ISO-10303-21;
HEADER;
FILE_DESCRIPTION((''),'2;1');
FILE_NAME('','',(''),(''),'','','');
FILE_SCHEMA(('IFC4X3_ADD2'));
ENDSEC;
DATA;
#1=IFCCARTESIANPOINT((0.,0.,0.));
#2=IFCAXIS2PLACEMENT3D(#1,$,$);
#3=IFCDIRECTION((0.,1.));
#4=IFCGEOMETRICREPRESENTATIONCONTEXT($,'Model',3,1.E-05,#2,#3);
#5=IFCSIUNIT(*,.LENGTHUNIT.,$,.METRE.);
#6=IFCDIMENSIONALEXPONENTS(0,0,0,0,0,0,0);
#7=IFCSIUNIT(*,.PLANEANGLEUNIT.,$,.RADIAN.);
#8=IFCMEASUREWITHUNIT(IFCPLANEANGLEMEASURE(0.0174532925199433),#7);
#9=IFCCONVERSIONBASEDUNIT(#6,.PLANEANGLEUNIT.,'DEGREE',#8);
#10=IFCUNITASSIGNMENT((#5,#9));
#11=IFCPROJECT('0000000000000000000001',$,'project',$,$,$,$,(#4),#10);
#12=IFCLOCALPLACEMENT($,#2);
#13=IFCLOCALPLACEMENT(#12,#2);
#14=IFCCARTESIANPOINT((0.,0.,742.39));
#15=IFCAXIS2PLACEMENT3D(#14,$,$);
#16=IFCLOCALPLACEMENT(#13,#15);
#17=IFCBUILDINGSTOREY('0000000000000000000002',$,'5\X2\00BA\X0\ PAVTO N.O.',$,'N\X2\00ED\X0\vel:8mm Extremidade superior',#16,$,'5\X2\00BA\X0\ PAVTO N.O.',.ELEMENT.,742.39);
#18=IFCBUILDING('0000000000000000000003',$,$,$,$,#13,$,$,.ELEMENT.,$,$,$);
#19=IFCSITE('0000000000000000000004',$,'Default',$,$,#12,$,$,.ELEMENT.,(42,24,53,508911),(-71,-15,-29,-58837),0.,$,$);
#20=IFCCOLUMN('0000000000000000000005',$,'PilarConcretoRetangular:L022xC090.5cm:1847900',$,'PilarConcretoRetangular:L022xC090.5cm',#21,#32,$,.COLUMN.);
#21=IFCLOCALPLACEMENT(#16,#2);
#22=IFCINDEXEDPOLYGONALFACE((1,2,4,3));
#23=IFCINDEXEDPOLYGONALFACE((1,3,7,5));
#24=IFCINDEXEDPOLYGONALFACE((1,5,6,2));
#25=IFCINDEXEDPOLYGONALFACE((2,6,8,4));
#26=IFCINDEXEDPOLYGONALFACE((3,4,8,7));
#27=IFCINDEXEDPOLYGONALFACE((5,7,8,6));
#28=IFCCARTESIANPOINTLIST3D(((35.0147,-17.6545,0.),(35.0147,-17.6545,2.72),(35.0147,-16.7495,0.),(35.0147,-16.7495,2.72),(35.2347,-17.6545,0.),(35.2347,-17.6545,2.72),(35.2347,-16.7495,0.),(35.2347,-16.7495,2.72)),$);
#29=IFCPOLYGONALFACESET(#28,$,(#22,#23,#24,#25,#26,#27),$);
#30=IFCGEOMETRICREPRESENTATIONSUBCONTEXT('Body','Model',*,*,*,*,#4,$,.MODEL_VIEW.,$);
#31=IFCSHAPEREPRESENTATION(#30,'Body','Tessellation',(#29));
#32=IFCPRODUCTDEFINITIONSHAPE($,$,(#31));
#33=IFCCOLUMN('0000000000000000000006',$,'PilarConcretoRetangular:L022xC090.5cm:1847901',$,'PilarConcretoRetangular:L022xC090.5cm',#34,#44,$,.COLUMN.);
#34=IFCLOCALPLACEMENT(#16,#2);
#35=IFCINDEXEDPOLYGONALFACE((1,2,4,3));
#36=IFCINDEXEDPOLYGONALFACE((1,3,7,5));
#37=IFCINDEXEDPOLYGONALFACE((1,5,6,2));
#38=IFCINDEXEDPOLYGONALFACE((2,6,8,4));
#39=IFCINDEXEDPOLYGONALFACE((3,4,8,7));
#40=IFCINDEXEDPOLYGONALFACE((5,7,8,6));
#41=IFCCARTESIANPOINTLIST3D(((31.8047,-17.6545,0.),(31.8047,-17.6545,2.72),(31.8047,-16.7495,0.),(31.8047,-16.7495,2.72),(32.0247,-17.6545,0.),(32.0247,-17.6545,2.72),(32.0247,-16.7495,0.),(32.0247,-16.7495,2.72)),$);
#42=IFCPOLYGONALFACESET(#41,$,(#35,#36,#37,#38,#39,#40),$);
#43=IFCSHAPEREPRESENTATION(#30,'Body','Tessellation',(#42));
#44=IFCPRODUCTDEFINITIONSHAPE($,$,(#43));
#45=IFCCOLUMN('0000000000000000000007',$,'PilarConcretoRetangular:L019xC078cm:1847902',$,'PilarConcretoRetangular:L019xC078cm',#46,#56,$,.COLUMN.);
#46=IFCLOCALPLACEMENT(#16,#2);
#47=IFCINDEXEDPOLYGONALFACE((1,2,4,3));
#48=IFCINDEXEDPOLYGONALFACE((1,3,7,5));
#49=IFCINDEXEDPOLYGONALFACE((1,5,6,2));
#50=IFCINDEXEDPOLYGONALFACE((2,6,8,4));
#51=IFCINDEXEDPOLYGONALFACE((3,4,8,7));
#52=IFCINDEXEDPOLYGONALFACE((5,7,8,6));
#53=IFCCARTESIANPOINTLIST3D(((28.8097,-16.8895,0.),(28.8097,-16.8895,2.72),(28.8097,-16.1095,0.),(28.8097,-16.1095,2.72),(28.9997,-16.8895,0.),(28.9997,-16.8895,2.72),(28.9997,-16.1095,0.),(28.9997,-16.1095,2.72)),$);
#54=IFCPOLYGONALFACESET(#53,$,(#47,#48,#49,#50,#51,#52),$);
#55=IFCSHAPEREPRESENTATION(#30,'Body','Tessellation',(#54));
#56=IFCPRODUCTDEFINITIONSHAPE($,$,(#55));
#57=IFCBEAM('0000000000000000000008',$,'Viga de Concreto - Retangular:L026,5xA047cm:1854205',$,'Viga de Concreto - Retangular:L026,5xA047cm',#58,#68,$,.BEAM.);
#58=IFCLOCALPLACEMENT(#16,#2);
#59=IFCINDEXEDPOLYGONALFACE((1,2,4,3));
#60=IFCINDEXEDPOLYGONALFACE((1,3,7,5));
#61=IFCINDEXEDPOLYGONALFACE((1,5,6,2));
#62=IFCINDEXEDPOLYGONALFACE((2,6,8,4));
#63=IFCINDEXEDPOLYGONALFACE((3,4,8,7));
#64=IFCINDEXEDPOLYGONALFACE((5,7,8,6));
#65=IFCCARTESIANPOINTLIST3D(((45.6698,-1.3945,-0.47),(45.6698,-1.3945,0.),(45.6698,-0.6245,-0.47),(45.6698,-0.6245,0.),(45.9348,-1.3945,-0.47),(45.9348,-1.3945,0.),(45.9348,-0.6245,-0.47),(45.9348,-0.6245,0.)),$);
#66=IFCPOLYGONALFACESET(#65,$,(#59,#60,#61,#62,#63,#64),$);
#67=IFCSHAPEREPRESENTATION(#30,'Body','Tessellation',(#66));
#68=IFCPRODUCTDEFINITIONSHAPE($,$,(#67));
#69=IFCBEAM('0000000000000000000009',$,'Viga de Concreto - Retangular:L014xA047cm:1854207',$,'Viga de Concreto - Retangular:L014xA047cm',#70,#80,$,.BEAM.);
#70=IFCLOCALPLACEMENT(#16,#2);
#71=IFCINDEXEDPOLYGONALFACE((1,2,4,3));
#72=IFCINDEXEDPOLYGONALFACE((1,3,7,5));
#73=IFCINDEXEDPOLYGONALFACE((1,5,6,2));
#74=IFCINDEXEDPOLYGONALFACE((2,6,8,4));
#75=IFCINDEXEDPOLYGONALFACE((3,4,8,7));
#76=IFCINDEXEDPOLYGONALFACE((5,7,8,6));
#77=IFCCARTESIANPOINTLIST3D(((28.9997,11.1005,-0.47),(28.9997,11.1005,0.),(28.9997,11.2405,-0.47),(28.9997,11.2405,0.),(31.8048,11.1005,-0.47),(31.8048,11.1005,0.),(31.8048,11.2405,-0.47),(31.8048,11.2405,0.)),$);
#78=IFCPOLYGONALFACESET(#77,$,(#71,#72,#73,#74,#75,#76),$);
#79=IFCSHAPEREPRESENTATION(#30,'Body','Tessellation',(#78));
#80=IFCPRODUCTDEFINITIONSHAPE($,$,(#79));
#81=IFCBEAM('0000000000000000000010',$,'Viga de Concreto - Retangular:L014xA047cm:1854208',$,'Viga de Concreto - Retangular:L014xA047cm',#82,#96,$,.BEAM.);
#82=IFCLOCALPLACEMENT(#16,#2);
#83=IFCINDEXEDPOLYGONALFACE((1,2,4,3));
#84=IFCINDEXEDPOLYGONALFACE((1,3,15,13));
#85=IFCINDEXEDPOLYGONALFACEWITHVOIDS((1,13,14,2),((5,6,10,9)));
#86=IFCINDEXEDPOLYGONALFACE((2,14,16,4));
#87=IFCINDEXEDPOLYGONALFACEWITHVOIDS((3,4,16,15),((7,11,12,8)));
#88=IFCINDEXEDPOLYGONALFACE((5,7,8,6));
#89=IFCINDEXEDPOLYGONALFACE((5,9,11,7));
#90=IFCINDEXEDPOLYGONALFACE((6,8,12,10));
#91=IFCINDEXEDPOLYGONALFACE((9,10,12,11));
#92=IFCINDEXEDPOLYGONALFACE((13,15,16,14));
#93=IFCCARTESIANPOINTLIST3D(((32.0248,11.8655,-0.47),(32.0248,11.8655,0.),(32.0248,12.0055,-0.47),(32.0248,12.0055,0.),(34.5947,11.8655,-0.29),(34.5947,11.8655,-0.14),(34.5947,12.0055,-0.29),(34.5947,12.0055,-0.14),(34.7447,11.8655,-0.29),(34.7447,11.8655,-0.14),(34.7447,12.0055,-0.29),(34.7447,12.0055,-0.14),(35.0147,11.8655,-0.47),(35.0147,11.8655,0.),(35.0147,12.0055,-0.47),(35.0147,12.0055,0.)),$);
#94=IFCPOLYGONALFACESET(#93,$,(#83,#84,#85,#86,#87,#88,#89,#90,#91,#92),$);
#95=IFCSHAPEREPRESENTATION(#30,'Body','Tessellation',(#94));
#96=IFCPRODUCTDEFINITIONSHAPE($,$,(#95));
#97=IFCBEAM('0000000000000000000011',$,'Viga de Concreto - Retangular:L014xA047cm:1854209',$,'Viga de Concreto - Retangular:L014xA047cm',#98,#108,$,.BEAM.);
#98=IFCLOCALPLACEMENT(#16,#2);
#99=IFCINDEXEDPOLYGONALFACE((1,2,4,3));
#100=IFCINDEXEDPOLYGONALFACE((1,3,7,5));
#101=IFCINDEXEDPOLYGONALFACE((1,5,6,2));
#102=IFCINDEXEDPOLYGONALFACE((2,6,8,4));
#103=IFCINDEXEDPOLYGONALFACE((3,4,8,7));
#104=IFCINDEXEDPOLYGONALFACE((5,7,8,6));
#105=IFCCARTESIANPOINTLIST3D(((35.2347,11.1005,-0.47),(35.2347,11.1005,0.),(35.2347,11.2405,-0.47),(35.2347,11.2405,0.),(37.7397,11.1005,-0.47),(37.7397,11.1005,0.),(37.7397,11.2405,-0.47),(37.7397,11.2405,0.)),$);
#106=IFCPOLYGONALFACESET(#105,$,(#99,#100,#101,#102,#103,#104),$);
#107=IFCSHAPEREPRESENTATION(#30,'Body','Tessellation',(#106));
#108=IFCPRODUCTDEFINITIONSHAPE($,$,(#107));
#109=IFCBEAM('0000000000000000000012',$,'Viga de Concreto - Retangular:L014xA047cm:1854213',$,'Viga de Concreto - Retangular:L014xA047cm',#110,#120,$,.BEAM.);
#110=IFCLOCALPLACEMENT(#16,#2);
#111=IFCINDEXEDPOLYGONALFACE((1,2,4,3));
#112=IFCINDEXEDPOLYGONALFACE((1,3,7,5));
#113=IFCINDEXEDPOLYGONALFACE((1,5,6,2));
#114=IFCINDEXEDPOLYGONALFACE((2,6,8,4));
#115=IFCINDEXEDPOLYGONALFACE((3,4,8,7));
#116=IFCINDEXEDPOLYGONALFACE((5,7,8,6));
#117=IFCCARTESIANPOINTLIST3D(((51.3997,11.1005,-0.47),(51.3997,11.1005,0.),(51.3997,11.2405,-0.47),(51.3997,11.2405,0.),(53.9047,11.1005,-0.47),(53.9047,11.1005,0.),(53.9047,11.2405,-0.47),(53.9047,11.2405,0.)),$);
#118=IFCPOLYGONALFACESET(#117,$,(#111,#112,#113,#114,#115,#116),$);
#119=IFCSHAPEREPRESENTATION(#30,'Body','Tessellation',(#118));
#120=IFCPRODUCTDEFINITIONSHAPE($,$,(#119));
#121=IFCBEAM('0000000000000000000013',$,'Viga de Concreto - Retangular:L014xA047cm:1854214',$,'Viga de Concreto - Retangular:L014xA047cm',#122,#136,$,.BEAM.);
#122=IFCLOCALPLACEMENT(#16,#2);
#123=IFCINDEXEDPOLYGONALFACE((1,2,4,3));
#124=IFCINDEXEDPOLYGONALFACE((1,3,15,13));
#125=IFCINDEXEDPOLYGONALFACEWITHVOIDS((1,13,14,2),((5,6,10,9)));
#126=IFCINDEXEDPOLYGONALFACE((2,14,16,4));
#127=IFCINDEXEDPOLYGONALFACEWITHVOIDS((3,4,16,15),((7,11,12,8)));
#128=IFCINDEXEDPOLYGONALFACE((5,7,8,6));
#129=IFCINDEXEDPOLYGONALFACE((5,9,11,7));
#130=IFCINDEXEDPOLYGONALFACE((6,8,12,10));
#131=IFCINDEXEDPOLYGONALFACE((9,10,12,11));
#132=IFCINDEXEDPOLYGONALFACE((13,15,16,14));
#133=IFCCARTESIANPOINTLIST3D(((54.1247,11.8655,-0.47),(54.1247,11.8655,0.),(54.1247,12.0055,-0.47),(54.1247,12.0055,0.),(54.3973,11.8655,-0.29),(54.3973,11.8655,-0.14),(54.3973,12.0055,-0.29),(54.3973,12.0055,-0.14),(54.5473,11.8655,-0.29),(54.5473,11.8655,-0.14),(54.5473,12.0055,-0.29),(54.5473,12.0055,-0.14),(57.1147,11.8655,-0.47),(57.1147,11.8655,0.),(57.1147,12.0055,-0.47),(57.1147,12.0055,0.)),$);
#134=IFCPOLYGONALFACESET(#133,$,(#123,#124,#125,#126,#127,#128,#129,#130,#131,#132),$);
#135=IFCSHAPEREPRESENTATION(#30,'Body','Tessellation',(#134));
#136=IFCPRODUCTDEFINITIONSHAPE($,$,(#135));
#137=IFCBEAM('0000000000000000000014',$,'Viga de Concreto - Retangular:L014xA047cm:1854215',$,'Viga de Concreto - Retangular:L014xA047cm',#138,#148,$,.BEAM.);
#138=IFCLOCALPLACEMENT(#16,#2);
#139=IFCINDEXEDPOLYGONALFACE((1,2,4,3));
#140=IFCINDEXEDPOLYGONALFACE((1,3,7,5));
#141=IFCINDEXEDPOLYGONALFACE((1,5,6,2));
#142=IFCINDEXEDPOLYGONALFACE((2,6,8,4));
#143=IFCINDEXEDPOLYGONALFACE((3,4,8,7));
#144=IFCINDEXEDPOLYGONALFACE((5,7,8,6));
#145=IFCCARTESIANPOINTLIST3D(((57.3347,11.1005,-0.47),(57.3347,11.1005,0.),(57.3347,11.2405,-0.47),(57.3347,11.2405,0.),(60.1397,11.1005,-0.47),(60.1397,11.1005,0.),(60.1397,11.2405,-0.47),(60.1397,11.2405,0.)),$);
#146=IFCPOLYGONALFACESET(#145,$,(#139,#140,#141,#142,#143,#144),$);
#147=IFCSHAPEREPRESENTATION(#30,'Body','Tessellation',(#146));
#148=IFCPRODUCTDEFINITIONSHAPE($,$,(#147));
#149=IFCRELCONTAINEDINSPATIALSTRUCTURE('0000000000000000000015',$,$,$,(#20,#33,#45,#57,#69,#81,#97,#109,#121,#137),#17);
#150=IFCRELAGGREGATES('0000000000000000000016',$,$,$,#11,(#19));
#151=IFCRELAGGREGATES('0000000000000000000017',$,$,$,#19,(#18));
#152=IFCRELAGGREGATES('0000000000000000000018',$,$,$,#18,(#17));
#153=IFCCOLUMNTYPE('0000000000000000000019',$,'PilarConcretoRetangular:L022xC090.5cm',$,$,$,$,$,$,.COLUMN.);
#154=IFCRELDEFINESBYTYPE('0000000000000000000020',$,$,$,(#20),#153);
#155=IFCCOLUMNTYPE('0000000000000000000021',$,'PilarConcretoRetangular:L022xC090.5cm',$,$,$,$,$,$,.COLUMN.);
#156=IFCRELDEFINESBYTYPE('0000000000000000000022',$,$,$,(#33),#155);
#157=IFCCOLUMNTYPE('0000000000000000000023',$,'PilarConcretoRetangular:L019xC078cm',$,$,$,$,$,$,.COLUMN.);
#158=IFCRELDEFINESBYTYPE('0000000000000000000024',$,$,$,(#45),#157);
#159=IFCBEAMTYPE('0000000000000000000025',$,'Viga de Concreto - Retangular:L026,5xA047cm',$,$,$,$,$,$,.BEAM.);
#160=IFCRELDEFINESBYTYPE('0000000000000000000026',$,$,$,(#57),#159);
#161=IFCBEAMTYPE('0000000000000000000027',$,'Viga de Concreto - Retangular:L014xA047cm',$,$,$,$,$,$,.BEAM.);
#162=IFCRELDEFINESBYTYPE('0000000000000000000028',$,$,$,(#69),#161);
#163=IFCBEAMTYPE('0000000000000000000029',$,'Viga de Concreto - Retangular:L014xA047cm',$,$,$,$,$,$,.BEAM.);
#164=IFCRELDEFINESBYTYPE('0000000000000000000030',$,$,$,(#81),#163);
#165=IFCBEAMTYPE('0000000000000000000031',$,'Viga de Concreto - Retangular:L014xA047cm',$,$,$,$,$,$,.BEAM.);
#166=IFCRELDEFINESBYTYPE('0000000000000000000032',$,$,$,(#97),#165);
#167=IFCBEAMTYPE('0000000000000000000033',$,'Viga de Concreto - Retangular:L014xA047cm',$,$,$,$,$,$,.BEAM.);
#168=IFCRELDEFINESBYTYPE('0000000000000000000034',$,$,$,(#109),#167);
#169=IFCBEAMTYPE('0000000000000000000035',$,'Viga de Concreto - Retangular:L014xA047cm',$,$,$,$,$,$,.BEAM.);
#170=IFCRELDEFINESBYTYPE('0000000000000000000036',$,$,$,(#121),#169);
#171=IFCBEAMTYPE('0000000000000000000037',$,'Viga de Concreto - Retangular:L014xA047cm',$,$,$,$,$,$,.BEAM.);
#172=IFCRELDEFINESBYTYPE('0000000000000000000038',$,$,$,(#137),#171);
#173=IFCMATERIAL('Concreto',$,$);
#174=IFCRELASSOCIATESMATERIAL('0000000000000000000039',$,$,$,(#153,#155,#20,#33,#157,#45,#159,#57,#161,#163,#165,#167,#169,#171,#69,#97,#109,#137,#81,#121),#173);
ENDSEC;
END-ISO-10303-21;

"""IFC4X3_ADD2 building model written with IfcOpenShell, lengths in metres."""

from ifc_helpers import new_model, entity, si_unit, converted_unit, direction, frame, frame_2d, origin, origin_2d_with_axis, place, context, subcontext, project, spatial, rectangle, extrude, boolean, source, transform, mapped, material, material_profile, profile_set, profile_usage, type_object, type_shapes, element, save


model = new_model("IFC4X3_ADD2")

# Units and contexts
model_context = context("Model", 3, precision=1e-05, world=origin(), true_north=direction((0.0, 1.0)))
body_context = subcontext(model_context, "Body", "Model", "MODEL_VIEW")
ifc_project = project(units=[si_unit("LENGTHUNIT", "METRE"), converted_unit("PLANEANGLEUNIT", "DEGREE", entity("IfcPlaneAngleMeasure", 0.0174532925199433), si_unit("PLANEANGLEUNIT", "RADIAN"), dimensions=[0, 0, 0, 0, 0, 0, 0])], contexts=[model_context])

# Site, building, storey
site_placement = place(None, origin())
site = spatial("IfcSite", under=ifc_project, at=site_placement, Name="Default", CompositionType="ELEMENT", RefLatitude=(42, 24, 53, 508911), RefLongitude=(-71, -15, -29, -58837), RefElevation=0.0)
building_placement = place(site_placement, origin())
building = spatial("IfcBuilding", under=site, at=building_placement, CompositionType="ELEMENT")
storey_placement = place(building_placement, frame((0.0, 0.0, 742.39)))
storey = spatial("IfcBuildingStorey", under=building, at=storey_placement, Name="5º PAVTO N.O.", ObjectType="Nível:8mm Extremidade superior", LongName="5º PAVTO N.O.", CompositionType="ELEMENT", Elevation=742.39)

# Columns
ifc_material = material(Name="Concreto")
ifc_material_profile_1 = material_profile(ifc_material, rectangle(XDim=0.22, YDim=0.905, at=frame_2d((0.0, 0.0), x_axis=(1.0, 0.0))), Name="L022xC090.5cm")
ifc_profile_set_1 = profile_set([ifc_material_profile_1], Name="L022xC090.5cm")
ifc_profile_usage_1 = profile_usage(ifc_profile_set_1)
column_type_1 = type_object("IfcColumnType", Name="PilarConcretoRetangular:L022xC090.5cm", PredefinedType="COLUMN", material=ifc_profile_set_1)
shared_shape_1 = source(origin(), body_context, "Body", "SweptSolid", [
    extrude(rectangle(XDim=0.22, YDim=0.905, at=frame_2d((0.0, 0.0), x_axis=(1.0, 0.0))), frame((35.1247, -17.202, 742.39), z_axis=(0.0, 0.0, 1.0), x_axis=(-1.0, 0.0, 0.0)), (0.0, 0.0, 1.0), 2.72),
])
type_shapes(column_type_1, [shared_shape_1])
column_1_placement = place(storey_placement, frame((0.0, 0.0, -742.39)))
element("IfcColumn", 1, at=column_1_placement, inside=storey, type_object=column_type_1, material=ifc_profile_usage_1, Name="PilarConcretoRetangular:L022xC090.5cm:1847900", ObjectType="PilarConcretoRetangular:L022xC090.5cm", PredefinedType="COLUMN", context=body_context, shape_type="MappedRepresentation", body=[
    mapped(shared_shape_1, transform((0.0, 0.0, 0.0), scale=1.0)),
])
column_type_2 = type_object("IfcColumnType", Name="PilarConcretoRetangular:L022xC090.5cm", PredefinedType="COLUMN", material=ifc_profile_set_1)
shared_shape_2 = source(origin(), body_context, "Body", "SweptSolid", [
    extrude(rectangle(XDim=0.22, YDim=0.905, at=frame_2d((0.0, 0.0), x_axis=(1.0, 0.0))), frame((31.9147, -17.202, 742.39), z_axis=(0.0, 0.0, 1.0), x_axis=(-1.0, 0.0, 0.0)), (0.0, 0.0, 1.0), 2.72),
])
type_shapes(column_type_2, [shared_shape_2])
column_2_placement = place(storey_placement, frame((0.0, 0.0, -742.39)))
element("IfcColumn", 2, at=column_2_placement, inside=storey, type_object=column_type_2, material=ifc_profile_usage_1, Name="PilarConcretoRetangular:L022xC090.5cm:1847901", ObjectType="PilarConcretoRetangular:L022xC090.5cm", PredefinedType="COLUMN", context=body_context, shape_type="MappedRepresentation", body=[
    mapped(shared_shape_2, transform((0.0, 0.0, 0.0), scale=1.0)),
])
ifc_material_profile_2 = material_profile(ifc_material, rectangle(XDim=0.19, YDim=0.78, at=frame_2d((0.0, 0.0), x_axis=(1.0, 0.0))), Name="L019xC078cm")
ifc_profile_set_2 = profile_set([ifc_material_profile_2], Name="L019xC078cm")
ifc_profile_usage_2 = profile_usage(ifc_profile_set_2)
column_type_3 = type_object("IfcColumnType", Name="PilarConcretoRetangular:L019xC078cm", PredefinedType="COLUMN", material=ifc_profile_set_2)
shared_shape_3 = source(origin(), body_context, "Body", "SweptSolid", [
    extrude(rectangle(XDim=0.19, YDim=0.78, at=frame_2d((0.0, 0.0), x_axis=(1.0, 0.0))), frame((28.9047, -16.4995, 742.39), z_axis=(0.0, 0.0, 1.0), x_axis=(-1.0, 0.0, 0.0)), (0.0, 0.0, 1.0), 2.72),
])
type_shapes(column_type_3, [shared_shape_3])
column_3_placement = place(storey_placement, frame((0.0, 0.0, -742.39)))
element("IfcColumn", 3, at=column_3_placement, inside=storey, type_object=column_type_3, material=ifc_profile_usage_2, Name="PilarConcretoRetangular:L019xC078cm:1847902", ObjectType="PilarConcretoRetangular:L019xC078cm", PredefinedType="COLUMN", context=body_context, shape_type="MappedRepresentation", body=[
    mapped(shared_shape_3, transform((0.0, 0.0, 0.0), scale=1.0)),
])

# Beams
ifc_material_profile_3 = material_profile(ifc_material, rectangle(XDim=0.47, YDim=0.265, at=frame_2d((0.0, 0.0), x_axis=(0.0, 1.0))), Name="L026,5xA047cm")
ifc_profile_set_3 = profile_set([ifc_material_profile_3], Name="L026,5xA047cm")
ifc_profile_usage_3 = profile_usage(ifc_profile_set_3, cardinal=8)
beam_type_1 = type_object("IfcBeamType", Name="Viga de Concreto - Retangular:L026,5xA047cm", PredefinedType="BEAM", material=ifc_profile_set_3)
shared_shape_4 = source(origin(), body_context, "Body", "SweptSolid", [
    extrude(rectangle(XDim=0.47, YDim=0.265, at=frame_2d((0.0, 0.0), x_axis=(0.0, 1.0))), frame((45.8023, -0.6245, 742.155), z_axis=(0.0, -1.0, 0.0), x_axis=(-1.0, 0.0, 0.0)), (0.0, 0.0, 1.0), 0.77),
])
type_shapes(beam_type_1, [shared_shape_4])
beam_1_placement = place(storey_placement, frame((0.0, 0.0, -742.39)))
element("IfcBeam", 4, at=beam_1_placement, inside=storey, type_object=beam_type_1, material=ifc_profile_usage_3, Name="Viga de Concreto - Retangular:L026,5xA047cm:1854205", ObjectType="Viga de Concreto - Retangular:L026,5xA047cm", PredefinedType="BEAM", context=body_context, shape_type="MappedRepresentation", body=[
    mapped(shared_shape_4, transform((0.0, 0.0, 0.0), scale=1.0)),
])
ifc_material_profile_4 = material_profile(ifc_material, rectangle(XDim=0.47, YDim=0.14, at=frame_2d((0.0, 0.0), x_axis=(0.0, 1.0))), Name="L014xA047cm")
ifc_profile_set_4 = profile_set([ifc_material_profile_4], Name="L014xA047cm")
ifc_profile_usage_4 = profile_usage(ifc_profile_set_4, cardinal=8)
beam_type_2 = type_object("IfcBeamType", Name="Viga de Concreto - Retangular:L014xA047cm", PredefinedType="BEAM", material=ifc_profile_set_4)
shared_shape_5 = source(origin(), body_context, "Body", "SweptSolid", [
    extrude(rectangle(XDim=0.47, YDim=0.14, at=origin_2d_with_axis()), frame((31.8048, 11.1705, 742.155), z_axis=(-1.0, 0.0, 0.0), x_axis=(0.0, 0.0, -1.0)), (0.0, 0.0, 1.0), 2.8051),
])
type_shapes(beam_type_2, [shared_shape_5])
beam_2_placement = place(storey_placement, frame((0.0, 0.0, -742.39)))
element("IfcBeam", 5, at=beam_2_placement, inside=storey, type_object=beam_type_2, material=ifc_profile_usage_4, Name="Viga de Concreto - Retangular:L014xA047cm:1854207", ObjectType="Viga de Concreto - Retangular:L014xA047cm", PredefinedType="BEAM", context=body_context, shape_type="MappedRepresentation", body=[
    mapped(shared_shape_5, transform((0.0, 0.0, 0.0), scale=1.0)),
])
beam_type_3 = type_object("IfcBeamType", Name="Viga de Concreto - Retangular:L014xA047cm", PredefinedType="BEAM", material=ifc_profile_set_4)
shared_shape_6 = source(origin(), body_context, "Body", "CSG", [
    boolean("DIFFERENCE", extrude(rectangle(XDim=0.47, YDim=0.14, at=frame_2d((0.0, 0.0), x_axis=(0.0, 1.0))), frame((32.0248, 11.9355, 742.155), z_axis=(1.0, 0.0, 0.0), x_axis=(0.0, 1.0, 0.0)), (0.0, 0.0, 1.0), 2.9899), extrude(rectangle(XDim=0.15, YDim=0.15, at=frame_2d((0.0, 0.0), x_axis=(0.0, 1.0))), frame((34.6697, 11.8655, 742.175), z_axis=(0.0, 1.0, 0.0), x_axis=(1.0, 0.0, 0.0)), (0.0, 0.0, 1.0), 0.14)),
])
type_shapes(beam_type_3, [shared_shape_6])
beam_3_placement = place(storey_placement, frame((0.0, 0.0, -742.39)))
element("IfcBeam", 6, at=beam_3_placement, inside=storey, type_object=beam_type_3, material=ifc_material, Name="Viga de Concreto - Retangular:L014xA047cm:1854208", ObjectType="Viga de Concreto - Retangular:L014xA047cm", PredefinedType="BEAM", context=body_context, shape_type="MappedRepresentation", body=[
    mapped(shared_shape_6, transform((0.0, 0.0, 0.0), scale=1.0)),
])
beam_type_4 = type_object("IfcBeamType", Name="Viga de Concreto - Retangular:L014xA047cm", PredefinedType="BEAM", material=ifc_profile_set_4)
shared_shape_7 = source(origin(), body_context, "Body", "SweptSolid", [
    extrude(rectangle(XDim=0.47, YDim=0.14, at=origin_2d_with_axis()), frame((35.2347, 11.1705, 742.155), z_axis=(1.0, 0.0, 0.0), x_axis=(0.0, 0.0, -1.0)), (0.0, 0.0, 1.0), 2.505),
])
type_shapes(beam_type_4, [shared_shape_7])
beam_4_placement = place(storey_placement, frame((0.0, 0.0, -742.39)))
element("IfcBeam", 7, at=beam_4_placement, inside=storey, type_object=beam_type_4, material=ifc_profile_usage_4, Name="Viga de Concreto - Retangular:L014xA047cm:1854209", ObjectType="Viga de Concreto - Retangular:L014xA047cm", PredefinedType="BEAM", context=body_context, shape_type="MappedRepresentation", body=[
    mapped(shared_shape_7, transform((0.0, 0.0, 0.0), scale=1.0)),
])
beam_type_5 = type_object("IfcBeamType", Name="Viga de Concreto - Retangular:L014xA047cm", PredefinedType="BEAM", material=ifc_profile_set_4)
shared_shape_8 = source(origin(), body_context, "Body", "SweptSolid", [
    extrude(rectangle(XDim=0.47, YDim=0.14, at=origin_2d_with_axis()), frame((51.3997, 11.1705, 742.155), z_axis=(1.0, 0.0, 0.0), x_axis=(0.0, 0.0, -1.0)), (0.0, 0.0, 1.0), 2.505),
])
type_shapes(beam_type_5, [shared_shape_8])
beam_5_placement = place(storey_placement, frame((0.0, 0.0, -742.39)))
element("IfcBeam", 8, at=beam_5_placement, inside=storey, type_object=beam_type_5, material=ifc_profile_usage_4, Name="Viga de Concreto - Retangular:L014xA047cm:1854213", ObjectType="Viga de Concreto - Retangular:L014xA047cm", PredefinedType="BEAM", context=body_context, shape_type="MappedRepresentation", body=[
    mapped(shared_shape_8, transform((0.0, 0.0, 0.0), scale=1.0)),
])
beam_type_6 = type_object("IfcBeamType", Name="Viga de Concreto - Retangular:L014xA047cm", PredefinedType="BEAM", material=ifc_profile_set_4)
shared_shape_9 = source(origin(), body_context, "Body", "CSG", [
    boolean("DIFFERENCE", extrude(rectangle(XDim=0.47, YDim=0.14, at=frame_2d((0.0, 0.0), x_axis=(0.0, 1.0))), frame((54.1247, 11.9355, 742.155), z_axis=(1.0, 0.0, 0.0), x_axis=(0.0, 1.0, 0.0)), (0.0, 0.0, 1.0), 2.99), extrude(rectangle(XDim=0.15, YDim=0.15, at=frame_2d((0.0, 0.0), x_axis=(0.0, 1.0))), frame((54.4723, 11.8655, 742.175), z_axis=(0.0, 1.0, 0.0), x_axis=(1.0, 0.0, 0.0)), (0.0, 0.0, 1.0), 0.14)),
])
type_shapes(beam_type_6, [shared_shape_9])
beam_6_placement = place(storey_placement, frame((0.0, 0.0, -742.39)))
element("IfcBeam", 9, at=beam_6_placement, inside=storey, type_object=beam_type_6, material=ifc_material, Name="Viga de Concreto - Retangular:L014xA047cm:1854214", ObjectType="Viga de Concreto - Retangular:L014xA047cm", PredefinedType="BEAM", context=body_context, shape_type="MappedRepresentation", body=[
    mapped(shared_shape_9, transform((0.0, 0.0, 0.0), scale=1.0)),
])
beam_type_7 = type_object("IfcBeamType", Name="Viga de Concreto - Retangular:L014xA047cm", PredefinedType="BEAM", material=ifc_profile_set_4)
shared_shape_10 = source(origin(), body_context, "Body", "SweptSolid", [
    extrude(rectangle(XDim=0.47, YDim=0.14, at=origin_2d_with_axis()), frame((57.3347, 11.1705, 742.155), z_axis=(1.0, 0.0, 0.0), x_axis=(0.0, 0.0, -1.0)), (0.0, 0.0, 1.0), 2.805),
])
type_shapes(beam_type_7, [shared_shape_10])
beam_7_placement = place(storey_placement, frame((0.0, 0.0, -742.39)))
element("IfcBeam", 10, at=beam_7_placement, inside=storey, type_object=beam_type_7, material=ifc_profile_usage_4, Name="Viga de Concreto - Retangular:L014xA047cm:1854215", ObjectType="Viga de Concreto - Retangular:L014xA047cm", PredefinedType="BEAM", context=body_context, shape_type="MappedRepresentation", body=[
    mapped(shared_shape_10, transform((0.0, 0.0, 0.0), scale=1.0)),
])

save(model, "model.ifc")
